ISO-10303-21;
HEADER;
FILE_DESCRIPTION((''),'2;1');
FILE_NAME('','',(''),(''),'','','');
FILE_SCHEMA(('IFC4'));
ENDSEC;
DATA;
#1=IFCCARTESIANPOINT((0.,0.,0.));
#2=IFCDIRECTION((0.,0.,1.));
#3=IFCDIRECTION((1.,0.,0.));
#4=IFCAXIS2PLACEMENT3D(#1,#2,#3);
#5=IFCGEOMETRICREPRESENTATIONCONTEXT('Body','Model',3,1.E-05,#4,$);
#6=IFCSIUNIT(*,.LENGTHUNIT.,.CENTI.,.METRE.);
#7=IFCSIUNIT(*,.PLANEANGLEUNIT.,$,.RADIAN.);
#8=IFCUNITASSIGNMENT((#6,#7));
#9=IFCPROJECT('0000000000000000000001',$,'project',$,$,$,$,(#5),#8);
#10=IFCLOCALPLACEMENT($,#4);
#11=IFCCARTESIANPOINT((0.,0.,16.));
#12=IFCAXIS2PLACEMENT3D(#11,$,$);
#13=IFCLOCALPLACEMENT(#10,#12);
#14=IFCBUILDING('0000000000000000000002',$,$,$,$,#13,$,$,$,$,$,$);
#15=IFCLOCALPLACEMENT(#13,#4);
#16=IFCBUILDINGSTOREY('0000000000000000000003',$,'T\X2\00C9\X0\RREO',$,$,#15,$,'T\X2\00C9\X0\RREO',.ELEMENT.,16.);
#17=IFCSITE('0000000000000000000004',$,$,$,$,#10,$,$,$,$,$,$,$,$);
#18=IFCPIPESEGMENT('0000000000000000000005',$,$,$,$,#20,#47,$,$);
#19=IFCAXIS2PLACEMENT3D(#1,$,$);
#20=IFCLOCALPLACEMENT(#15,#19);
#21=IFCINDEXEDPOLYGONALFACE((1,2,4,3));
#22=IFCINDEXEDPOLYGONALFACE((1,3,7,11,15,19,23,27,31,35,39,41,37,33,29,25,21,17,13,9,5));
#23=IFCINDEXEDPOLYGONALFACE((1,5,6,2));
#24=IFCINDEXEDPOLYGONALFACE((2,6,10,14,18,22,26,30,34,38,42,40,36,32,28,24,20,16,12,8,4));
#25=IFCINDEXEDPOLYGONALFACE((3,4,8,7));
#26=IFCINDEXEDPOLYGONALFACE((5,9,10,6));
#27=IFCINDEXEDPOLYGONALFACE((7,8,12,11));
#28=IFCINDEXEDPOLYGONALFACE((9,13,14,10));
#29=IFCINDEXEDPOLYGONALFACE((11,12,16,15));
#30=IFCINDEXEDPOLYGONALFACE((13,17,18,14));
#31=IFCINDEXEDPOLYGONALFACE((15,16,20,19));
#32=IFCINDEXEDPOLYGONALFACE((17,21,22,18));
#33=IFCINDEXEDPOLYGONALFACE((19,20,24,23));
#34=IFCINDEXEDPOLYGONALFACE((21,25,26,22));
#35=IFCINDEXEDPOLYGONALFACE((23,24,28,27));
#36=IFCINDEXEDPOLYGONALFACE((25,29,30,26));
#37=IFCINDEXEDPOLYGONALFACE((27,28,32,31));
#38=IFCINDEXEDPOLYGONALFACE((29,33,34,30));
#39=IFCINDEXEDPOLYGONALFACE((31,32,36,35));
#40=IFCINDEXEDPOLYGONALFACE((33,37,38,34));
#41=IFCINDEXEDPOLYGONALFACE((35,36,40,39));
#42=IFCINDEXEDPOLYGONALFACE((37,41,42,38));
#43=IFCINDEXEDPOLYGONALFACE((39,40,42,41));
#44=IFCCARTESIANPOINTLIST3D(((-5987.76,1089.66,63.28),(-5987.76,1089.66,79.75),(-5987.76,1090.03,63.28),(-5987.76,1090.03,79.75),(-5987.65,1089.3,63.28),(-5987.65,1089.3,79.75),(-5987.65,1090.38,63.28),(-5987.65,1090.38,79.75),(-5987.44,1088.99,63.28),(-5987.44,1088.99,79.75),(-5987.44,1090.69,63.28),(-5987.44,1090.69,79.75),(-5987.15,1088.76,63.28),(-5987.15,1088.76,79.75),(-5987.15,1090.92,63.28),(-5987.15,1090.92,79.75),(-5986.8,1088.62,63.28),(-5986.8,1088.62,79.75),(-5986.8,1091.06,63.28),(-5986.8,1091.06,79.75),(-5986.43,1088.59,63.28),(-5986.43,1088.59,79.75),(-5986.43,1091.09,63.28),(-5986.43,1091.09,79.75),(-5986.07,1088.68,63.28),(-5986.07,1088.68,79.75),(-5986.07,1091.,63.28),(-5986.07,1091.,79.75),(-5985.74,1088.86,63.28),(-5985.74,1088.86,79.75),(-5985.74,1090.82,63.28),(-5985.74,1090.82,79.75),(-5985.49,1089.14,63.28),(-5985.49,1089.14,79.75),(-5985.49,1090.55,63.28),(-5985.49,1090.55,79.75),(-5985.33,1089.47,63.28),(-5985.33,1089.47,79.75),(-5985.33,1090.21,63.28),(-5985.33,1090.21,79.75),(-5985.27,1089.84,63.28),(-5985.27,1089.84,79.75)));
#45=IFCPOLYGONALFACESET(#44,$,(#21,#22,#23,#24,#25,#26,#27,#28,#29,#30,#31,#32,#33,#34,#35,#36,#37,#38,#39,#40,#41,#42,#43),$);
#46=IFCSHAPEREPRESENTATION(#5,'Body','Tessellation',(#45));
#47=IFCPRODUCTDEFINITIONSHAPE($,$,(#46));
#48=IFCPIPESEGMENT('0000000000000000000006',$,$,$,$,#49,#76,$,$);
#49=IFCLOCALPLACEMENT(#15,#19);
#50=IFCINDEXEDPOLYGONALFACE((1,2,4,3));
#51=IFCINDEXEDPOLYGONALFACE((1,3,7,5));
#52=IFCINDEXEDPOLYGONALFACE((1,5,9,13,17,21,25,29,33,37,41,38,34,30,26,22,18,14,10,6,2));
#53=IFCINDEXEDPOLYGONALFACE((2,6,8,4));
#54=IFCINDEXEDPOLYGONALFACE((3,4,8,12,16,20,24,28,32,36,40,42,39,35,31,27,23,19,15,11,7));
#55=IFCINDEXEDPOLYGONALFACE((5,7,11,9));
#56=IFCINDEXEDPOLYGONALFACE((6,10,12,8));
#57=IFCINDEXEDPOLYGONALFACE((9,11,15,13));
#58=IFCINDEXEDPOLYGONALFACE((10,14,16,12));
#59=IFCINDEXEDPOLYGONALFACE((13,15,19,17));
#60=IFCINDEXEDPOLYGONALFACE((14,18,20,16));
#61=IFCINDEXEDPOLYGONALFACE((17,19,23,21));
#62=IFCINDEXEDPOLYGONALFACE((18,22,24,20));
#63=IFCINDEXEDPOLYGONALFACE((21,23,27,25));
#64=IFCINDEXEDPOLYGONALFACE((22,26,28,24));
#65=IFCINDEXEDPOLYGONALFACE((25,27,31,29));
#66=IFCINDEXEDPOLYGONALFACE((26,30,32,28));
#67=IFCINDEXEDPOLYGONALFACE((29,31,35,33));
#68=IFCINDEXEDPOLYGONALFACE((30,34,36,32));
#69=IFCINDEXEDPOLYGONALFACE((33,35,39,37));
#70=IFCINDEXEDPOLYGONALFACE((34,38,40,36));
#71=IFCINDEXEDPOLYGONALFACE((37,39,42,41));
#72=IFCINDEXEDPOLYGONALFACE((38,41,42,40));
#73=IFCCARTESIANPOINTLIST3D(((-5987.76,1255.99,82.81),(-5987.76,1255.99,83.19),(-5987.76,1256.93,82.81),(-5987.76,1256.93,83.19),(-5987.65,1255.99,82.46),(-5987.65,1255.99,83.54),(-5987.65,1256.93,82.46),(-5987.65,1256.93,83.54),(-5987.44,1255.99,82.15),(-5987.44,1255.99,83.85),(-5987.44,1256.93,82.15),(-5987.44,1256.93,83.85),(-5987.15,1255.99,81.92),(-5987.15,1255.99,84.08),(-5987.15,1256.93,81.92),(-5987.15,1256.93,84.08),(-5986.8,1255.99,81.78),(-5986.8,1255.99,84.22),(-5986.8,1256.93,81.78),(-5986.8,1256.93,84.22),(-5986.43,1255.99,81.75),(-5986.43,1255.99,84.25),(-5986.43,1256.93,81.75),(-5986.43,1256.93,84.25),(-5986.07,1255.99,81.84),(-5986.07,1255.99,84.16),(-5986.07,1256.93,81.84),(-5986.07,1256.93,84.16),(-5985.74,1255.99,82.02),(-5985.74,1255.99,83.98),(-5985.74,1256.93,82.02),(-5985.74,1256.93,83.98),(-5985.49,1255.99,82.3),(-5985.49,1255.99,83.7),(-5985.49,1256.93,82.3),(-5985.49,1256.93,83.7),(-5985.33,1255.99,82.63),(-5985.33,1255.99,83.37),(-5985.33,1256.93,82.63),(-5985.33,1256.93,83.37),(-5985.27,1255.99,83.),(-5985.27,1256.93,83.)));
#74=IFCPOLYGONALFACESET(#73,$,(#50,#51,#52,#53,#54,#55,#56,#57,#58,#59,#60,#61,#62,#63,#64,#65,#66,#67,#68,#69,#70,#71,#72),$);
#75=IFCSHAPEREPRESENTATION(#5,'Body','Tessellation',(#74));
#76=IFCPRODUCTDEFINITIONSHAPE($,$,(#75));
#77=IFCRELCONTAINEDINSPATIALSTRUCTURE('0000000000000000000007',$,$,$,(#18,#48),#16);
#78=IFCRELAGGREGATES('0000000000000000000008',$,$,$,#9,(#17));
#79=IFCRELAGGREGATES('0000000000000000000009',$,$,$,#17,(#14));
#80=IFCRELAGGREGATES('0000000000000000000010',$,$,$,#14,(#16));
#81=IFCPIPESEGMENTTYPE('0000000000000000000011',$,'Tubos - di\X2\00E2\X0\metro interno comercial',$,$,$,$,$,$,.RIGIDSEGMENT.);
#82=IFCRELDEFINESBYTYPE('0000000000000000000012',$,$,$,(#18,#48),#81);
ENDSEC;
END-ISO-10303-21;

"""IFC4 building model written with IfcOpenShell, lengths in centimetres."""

from ifc_helpers import new_model, si_unit, frame, origin_with_axes, origin_2d_with_axis, place, context, project, spatial, circle, extrude, type_object, element, save


model = new_model("IFC4")

# Units and contexts
model_context = context("Model", 3, precision=1e-05, world=origin_with_axes(), identifier="Body")
ifc_project = project(units=[si_unit("LENGTHUNIT", "METRE", prefix="CENTI"), si_unit("PLANEANGLEUNIT", "RADIAN")], contexts=[model_context])

# Site, building, storey
site_placement = place(None, origin_with_axes())
site = spatial("IfcSite", under=ifc_project, at=site_placement)
building_placement = place(site_placement, frame((0.0, 0.0, 16.0)))
building = spatial("IfcBuilding", under=site, at=building_placement)
storey_placement = place(building_placement, origin_with_axes())
storey = spatial("IfcBuildingStorey", under=building, at=storey_placement, Name="TÉRREO", LongName="TÉRREO", CompositionType="ELEMENT", Elevation=16.0)

# Pipe segments
pipe_segment_type = type_object("IfcPipeSegmentType", Name="Tubos - diâmetro interno comercial", PredefinedType="RIGIDSEGMENT")
pipe_segment_1_placement = place(storey_placement, frame((-5986.52, 1089.84, 79.75), z_axis=(0.0, 0.0, 1.0), x_axis=(1.0, 0.0, 0.0)))
element("IfcPipeSegment", 1, at=pipe_segment_1_placement, inside=storey, type_object=pipe_segment_type, context=model_context, shape_type="SolidModel", body=[
    extrude(circle(Radius=1.25, at=origin_2d_with_axis()), frame((0.0, 0.0, 0.0), z_axis=(0.0, 0.0, -1.0), x_axis=(1.0, 0.0, 0.0)), (0.0, 0.0, 1.0), 16.47),
])
pipe_segment_2_placement = place(storey_placement, frame((-5986.52, 1256.46, 84.25), z_axis=(0.0, 0.0, 1.0), x_axis=(1.0, 0.0, 0.0)))
element("IfcPipeSegment", 2, at=pipe_segment_2_placement, inside=storey, type_object=pipe_segment_type, context=model_context, shape_type="SolidModel", body=[
    extrude(circle(Radius=1.25, at=origin_2d_with_axis()), frame((0.0, 0.47, -1.25), z_axis=(0.0, -1.0, 0.0), x_axis=(1.0, 0.0, 0.0)), (0.0, 0.0, 1.0), 0.94),
])

save(model, "model.ifc")
